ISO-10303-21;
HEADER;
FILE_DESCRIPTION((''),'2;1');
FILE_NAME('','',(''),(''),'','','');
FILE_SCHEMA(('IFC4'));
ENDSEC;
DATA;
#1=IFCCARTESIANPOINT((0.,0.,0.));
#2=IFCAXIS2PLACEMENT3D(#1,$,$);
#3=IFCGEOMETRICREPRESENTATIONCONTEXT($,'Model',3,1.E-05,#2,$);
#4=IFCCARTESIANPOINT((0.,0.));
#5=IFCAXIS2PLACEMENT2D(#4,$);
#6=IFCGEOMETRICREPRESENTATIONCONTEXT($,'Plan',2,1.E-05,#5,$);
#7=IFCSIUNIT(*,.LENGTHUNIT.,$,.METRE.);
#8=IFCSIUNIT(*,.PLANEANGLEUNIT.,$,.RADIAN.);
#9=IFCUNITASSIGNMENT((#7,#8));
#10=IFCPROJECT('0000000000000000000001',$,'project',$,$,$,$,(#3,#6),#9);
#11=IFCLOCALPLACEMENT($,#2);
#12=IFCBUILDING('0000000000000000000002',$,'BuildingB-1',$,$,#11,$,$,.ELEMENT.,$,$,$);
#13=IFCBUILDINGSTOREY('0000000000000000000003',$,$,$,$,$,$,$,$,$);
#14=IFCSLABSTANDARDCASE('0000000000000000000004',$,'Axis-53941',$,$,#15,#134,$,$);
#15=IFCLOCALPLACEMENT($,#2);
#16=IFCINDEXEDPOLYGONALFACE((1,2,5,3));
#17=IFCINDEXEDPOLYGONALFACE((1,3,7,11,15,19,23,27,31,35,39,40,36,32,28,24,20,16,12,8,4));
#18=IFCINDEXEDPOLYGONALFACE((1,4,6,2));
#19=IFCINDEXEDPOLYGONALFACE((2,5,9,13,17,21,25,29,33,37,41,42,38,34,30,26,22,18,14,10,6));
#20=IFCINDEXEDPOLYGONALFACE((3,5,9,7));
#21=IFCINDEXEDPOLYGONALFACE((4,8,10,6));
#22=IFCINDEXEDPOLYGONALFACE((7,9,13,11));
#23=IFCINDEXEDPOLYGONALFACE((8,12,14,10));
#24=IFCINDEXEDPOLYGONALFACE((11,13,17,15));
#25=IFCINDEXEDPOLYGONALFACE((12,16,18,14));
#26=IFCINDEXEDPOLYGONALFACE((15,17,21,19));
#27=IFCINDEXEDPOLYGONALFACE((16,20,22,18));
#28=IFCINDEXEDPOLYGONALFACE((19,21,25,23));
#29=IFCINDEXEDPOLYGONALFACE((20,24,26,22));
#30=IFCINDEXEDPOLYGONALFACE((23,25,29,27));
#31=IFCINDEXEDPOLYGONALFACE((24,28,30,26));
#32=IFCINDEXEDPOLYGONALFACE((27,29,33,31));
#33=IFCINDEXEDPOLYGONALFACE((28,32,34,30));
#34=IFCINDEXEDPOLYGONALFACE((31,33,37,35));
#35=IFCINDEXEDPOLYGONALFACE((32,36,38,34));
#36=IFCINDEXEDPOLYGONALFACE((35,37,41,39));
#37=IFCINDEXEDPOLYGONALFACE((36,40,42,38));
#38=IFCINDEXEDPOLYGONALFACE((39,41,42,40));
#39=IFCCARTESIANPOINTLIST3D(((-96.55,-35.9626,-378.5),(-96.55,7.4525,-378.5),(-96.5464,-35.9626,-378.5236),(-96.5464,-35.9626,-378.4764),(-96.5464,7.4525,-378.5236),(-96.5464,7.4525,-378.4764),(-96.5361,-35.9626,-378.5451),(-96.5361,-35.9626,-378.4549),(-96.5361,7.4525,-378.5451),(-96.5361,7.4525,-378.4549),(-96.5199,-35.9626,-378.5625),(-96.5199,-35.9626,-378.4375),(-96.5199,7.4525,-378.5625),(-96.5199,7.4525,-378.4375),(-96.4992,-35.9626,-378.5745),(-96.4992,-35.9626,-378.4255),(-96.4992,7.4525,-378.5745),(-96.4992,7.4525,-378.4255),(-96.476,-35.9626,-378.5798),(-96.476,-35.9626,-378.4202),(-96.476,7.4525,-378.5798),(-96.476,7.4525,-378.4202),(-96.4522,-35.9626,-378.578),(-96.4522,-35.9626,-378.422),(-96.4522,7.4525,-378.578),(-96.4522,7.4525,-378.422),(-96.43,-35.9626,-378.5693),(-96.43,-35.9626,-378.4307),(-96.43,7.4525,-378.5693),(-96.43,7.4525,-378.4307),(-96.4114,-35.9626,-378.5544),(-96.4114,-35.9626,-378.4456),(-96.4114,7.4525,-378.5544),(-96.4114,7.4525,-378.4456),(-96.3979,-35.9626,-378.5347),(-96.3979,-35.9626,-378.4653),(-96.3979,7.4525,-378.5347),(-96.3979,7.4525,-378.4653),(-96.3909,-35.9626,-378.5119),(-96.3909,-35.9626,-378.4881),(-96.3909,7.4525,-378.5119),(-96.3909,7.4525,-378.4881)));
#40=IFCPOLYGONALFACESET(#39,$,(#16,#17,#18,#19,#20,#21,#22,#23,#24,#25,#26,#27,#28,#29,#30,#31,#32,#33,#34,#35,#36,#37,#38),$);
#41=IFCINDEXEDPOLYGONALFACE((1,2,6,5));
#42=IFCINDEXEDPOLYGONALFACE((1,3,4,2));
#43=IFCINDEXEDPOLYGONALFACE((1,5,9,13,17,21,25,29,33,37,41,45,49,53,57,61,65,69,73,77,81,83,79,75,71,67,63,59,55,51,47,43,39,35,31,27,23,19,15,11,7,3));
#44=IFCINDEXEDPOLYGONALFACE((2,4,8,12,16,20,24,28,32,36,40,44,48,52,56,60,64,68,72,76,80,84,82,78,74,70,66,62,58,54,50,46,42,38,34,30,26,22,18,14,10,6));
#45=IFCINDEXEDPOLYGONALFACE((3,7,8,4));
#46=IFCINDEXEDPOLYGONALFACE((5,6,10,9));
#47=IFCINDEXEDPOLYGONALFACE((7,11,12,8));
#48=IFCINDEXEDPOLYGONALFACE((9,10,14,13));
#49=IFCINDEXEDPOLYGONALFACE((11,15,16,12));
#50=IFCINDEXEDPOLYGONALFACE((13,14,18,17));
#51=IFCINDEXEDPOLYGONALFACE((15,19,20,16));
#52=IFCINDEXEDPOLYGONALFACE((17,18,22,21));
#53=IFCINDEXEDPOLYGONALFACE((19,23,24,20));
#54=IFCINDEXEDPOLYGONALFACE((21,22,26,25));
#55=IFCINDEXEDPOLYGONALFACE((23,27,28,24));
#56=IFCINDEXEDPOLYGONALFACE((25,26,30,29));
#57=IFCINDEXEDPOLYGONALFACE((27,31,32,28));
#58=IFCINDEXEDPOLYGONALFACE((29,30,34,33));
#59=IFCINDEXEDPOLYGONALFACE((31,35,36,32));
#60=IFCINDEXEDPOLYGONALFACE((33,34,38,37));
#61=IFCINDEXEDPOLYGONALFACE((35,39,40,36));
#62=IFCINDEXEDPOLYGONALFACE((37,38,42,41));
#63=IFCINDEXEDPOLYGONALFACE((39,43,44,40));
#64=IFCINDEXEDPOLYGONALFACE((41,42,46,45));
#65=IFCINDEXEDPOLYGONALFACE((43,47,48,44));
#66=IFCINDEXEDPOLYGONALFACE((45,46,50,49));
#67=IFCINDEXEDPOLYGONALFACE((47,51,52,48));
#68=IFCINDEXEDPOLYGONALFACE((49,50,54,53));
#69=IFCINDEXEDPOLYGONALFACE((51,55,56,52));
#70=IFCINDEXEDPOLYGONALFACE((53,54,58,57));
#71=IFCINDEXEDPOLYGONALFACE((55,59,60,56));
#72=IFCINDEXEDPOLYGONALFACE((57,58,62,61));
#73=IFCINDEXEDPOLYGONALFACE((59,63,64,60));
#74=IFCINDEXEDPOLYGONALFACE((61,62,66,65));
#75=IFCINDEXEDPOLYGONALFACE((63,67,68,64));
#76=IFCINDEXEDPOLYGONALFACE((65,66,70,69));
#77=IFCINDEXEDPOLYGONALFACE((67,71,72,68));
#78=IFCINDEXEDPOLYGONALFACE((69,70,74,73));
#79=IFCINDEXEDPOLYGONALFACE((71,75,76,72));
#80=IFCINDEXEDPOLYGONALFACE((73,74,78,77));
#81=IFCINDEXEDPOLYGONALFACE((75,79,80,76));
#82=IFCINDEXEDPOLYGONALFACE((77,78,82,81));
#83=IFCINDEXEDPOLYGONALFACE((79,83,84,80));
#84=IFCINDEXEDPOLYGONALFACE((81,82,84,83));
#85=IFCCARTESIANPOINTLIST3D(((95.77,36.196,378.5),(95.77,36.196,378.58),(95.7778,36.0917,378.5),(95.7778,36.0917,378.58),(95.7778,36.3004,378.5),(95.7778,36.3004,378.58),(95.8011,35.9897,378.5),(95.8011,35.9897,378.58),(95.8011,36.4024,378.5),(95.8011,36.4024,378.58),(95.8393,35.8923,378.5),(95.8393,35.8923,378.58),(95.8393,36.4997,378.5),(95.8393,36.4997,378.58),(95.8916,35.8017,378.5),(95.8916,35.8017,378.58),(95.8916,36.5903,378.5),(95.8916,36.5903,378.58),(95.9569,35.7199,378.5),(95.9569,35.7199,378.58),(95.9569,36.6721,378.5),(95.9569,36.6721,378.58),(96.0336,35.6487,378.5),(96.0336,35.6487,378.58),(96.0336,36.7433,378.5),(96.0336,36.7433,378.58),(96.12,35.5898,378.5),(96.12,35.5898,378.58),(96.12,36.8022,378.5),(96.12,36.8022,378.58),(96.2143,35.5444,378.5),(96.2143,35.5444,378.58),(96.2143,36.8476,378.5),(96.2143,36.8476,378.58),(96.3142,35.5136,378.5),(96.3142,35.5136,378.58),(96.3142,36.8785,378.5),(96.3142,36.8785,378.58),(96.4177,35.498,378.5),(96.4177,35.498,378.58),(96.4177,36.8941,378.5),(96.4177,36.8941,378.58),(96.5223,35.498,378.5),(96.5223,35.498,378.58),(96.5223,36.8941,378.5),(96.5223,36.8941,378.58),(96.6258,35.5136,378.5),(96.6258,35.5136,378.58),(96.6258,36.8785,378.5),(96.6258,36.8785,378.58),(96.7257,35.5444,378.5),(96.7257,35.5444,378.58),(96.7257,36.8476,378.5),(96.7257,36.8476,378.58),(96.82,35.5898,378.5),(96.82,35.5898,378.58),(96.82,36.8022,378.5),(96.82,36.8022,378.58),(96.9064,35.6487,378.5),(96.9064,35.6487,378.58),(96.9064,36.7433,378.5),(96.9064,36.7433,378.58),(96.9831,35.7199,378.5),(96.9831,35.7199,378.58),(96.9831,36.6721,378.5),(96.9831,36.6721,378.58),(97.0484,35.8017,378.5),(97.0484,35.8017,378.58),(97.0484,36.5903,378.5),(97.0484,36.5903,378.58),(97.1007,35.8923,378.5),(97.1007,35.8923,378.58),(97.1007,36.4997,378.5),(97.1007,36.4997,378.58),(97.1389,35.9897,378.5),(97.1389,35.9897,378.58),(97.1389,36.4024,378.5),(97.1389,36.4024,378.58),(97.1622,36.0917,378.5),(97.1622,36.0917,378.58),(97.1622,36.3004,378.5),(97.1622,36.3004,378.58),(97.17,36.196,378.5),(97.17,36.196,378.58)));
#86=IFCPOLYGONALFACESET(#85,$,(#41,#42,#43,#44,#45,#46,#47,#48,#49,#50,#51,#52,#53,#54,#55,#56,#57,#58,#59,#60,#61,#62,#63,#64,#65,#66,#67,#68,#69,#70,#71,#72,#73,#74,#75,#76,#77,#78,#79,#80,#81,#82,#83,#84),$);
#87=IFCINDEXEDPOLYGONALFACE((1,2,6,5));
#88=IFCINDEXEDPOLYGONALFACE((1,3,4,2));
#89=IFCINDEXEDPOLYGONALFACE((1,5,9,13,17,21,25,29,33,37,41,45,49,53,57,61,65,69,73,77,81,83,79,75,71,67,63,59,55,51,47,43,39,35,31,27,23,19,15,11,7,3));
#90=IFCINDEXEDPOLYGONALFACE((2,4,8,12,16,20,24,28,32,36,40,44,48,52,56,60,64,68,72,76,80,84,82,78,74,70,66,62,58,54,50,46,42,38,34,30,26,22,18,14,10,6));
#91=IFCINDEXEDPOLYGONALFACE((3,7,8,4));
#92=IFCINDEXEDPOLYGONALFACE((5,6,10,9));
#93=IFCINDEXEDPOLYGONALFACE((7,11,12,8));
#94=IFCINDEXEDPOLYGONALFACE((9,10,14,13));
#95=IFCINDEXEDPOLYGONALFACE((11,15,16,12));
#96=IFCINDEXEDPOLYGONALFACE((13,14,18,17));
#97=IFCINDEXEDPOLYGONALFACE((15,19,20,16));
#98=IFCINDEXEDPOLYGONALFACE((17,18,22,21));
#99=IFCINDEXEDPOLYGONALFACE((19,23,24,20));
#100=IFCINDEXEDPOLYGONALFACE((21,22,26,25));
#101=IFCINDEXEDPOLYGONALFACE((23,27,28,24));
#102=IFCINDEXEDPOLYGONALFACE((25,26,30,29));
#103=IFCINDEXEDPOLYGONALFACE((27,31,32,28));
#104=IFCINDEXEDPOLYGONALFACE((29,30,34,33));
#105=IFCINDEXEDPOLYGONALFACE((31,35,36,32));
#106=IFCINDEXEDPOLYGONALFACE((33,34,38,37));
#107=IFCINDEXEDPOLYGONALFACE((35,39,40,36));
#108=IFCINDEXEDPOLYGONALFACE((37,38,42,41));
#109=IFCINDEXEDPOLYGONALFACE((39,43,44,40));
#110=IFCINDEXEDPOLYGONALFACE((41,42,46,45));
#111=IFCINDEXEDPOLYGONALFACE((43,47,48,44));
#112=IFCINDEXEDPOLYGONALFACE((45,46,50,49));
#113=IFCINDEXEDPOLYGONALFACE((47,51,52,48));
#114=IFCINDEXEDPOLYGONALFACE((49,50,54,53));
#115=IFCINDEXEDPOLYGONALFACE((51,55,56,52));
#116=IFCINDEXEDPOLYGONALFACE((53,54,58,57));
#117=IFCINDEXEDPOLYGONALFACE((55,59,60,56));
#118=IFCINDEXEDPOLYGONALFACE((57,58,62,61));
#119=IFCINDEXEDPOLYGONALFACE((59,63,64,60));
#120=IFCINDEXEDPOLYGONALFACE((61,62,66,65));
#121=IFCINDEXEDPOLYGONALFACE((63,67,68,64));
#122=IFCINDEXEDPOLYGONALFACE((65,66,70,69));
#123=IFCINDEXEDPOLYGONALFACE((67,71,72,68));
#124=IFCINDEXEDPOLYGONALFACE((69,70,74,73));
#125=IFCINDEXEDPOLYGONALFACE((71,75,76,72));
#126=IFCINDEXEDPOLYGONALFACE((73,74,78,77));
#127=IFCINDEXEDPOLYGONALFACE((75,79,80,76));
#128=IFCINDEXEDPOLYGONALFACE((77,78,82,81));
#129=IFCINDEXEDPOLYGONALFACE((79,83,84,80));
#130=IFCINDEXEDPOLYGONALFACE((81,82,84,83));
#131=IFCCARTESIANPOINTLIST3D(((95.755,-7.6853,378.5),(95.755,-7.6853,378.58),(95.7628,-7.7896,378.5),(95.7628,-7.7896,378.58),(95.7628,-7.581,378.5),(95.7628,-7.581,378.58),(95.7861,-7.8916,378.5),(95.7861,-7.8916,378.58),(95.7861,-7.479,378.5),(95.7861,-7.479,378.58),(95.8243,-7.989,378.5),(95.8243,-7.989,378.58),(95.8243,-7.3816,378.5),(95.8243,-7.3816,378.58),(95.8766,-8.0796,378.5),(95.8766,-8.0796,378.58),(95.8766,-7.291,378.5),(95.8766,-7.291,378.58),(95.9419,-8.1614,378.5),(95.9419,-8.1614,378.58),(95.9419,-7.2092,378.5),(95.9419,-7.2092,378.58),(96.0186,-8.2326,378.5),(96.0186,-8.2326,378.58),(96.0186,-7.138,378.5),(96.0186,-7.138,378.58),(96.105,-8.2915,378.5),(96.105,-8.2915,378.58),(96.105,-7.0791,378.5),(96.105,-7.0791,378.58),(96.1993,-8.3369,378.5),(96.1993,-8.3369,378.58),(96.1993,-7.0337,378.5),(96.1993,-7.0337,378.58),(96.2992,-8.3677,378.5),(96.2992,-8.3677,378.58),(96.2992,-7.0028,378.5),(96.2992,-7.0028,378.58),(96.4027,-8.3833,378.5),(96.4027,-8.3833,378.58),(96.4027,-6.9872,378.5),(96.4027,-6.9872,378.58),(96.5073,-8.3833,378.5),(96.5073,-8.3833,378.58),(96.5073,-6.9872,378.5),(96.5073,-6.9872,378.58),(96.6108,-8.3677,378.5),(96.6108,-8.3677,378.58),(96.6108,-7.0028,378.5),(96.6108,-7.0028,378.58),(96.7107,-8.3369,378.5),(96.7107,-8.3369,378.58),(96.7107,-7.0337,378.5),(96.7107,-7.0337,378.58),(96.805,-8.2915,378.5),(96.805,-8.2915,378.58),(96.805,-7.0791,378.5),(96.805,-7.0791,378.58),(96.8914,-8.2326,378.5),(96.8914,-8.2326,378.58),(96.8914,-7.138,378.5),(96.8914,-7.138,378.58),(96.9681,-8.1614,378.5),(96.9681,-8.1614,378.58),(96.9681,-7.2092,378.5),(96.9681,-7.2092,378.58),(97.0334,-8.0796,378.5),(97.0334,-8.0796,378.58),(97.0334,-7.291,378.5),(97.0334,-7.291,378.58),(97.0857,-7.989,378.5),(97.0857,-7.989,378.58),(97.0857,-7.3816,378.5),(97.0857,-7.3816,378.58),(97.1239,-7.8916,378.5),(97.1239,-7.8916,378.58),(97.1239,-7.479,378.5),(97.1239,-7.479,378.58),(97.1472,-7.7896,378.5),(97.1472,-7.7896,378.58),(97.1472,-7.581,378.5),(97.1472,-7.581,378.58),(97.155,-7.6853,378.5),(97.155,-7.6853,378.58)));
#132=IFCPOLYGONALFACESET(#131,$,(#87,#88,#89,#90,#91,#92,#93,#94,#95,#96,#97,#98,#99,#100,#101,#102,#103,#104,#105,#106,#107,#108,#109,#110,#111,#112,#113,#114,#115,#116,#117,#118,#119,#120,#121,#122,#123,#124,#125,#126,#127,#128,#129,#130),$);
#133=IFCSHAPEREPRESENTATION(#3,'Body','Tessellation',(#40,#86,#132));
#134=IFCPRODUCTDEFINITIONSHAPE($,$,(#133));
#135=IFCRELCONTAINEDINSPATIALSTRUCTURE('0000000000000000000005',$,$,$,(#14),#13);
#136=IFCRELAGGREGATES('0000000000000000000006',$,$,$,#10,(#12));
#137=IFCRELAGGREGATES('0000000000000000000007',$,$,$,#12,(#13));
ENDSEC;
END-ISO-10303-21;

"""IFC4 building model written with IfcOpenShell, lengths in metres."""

from ifc_helpers import new_model, entity, si_unit, frame, origin, origin_2d, place, context, project, spatial, circle, extrude, element, save


model = new_model("IFC4")

# Units and contexts
model_context = context("Model", 3, precision=1e-05, world=origin())
plan_context = context("Plan", 2, precision=1e-05, world=origin_2d())
ifc_project = project(units=[si_unit("LENGTHUNIT", "METRE"), si_unit("PLANEANGLEUNIT", "RADIAN")], contexts=[model_context, plan_context])

# Building, storey
building_placement = place(None, origin())
building = spatial("IfcBuilding", under=ifc_project, at=building_placement, Name="BuildingB-1", CompositionType="ELEMENT")
storey = spatial("IfcBuildingStorey", under=building)

# Slab
element("IfcSlabStandardCase", 1, inside=storey, Name="Axis-53941", context=model_context, shape_type="AdvancedSweptSolid", body=[
    entity("IfcSurfaceCurveSweptAreaSolid", entity("IfcCircleProfileDef", "AREA", None, None, 0.08), None, entity("IfcPolyline", [entity("IfcCartesianPoint", [96.47, 35.9626, 378.5]), entity("IfcCartesianPoint", [96.47, -7.4525, 378.5])]), None, None, entity("IfcPlane", entity("IfcAxis2Placement3D", entity("IfcCartesianPoint", [96.47, 35.9626, 378.5]), entity("IfcDirection", [0.0, 0.0, 1.0]), entity("IfcDirection", [1.0, 0.0, 0.0])))),
    extrude(circle(Radius=0.7), frame((96.47, 36.196, 378.5)), (0.0, 0.0, 1.0), 0.08),
    extrude(circle(Radius=0.7), frame((96.455, -7.6853, 378.5)), (0.0, 0.0, 1.0), 0.08),
])

save(model, "model.ifc")
